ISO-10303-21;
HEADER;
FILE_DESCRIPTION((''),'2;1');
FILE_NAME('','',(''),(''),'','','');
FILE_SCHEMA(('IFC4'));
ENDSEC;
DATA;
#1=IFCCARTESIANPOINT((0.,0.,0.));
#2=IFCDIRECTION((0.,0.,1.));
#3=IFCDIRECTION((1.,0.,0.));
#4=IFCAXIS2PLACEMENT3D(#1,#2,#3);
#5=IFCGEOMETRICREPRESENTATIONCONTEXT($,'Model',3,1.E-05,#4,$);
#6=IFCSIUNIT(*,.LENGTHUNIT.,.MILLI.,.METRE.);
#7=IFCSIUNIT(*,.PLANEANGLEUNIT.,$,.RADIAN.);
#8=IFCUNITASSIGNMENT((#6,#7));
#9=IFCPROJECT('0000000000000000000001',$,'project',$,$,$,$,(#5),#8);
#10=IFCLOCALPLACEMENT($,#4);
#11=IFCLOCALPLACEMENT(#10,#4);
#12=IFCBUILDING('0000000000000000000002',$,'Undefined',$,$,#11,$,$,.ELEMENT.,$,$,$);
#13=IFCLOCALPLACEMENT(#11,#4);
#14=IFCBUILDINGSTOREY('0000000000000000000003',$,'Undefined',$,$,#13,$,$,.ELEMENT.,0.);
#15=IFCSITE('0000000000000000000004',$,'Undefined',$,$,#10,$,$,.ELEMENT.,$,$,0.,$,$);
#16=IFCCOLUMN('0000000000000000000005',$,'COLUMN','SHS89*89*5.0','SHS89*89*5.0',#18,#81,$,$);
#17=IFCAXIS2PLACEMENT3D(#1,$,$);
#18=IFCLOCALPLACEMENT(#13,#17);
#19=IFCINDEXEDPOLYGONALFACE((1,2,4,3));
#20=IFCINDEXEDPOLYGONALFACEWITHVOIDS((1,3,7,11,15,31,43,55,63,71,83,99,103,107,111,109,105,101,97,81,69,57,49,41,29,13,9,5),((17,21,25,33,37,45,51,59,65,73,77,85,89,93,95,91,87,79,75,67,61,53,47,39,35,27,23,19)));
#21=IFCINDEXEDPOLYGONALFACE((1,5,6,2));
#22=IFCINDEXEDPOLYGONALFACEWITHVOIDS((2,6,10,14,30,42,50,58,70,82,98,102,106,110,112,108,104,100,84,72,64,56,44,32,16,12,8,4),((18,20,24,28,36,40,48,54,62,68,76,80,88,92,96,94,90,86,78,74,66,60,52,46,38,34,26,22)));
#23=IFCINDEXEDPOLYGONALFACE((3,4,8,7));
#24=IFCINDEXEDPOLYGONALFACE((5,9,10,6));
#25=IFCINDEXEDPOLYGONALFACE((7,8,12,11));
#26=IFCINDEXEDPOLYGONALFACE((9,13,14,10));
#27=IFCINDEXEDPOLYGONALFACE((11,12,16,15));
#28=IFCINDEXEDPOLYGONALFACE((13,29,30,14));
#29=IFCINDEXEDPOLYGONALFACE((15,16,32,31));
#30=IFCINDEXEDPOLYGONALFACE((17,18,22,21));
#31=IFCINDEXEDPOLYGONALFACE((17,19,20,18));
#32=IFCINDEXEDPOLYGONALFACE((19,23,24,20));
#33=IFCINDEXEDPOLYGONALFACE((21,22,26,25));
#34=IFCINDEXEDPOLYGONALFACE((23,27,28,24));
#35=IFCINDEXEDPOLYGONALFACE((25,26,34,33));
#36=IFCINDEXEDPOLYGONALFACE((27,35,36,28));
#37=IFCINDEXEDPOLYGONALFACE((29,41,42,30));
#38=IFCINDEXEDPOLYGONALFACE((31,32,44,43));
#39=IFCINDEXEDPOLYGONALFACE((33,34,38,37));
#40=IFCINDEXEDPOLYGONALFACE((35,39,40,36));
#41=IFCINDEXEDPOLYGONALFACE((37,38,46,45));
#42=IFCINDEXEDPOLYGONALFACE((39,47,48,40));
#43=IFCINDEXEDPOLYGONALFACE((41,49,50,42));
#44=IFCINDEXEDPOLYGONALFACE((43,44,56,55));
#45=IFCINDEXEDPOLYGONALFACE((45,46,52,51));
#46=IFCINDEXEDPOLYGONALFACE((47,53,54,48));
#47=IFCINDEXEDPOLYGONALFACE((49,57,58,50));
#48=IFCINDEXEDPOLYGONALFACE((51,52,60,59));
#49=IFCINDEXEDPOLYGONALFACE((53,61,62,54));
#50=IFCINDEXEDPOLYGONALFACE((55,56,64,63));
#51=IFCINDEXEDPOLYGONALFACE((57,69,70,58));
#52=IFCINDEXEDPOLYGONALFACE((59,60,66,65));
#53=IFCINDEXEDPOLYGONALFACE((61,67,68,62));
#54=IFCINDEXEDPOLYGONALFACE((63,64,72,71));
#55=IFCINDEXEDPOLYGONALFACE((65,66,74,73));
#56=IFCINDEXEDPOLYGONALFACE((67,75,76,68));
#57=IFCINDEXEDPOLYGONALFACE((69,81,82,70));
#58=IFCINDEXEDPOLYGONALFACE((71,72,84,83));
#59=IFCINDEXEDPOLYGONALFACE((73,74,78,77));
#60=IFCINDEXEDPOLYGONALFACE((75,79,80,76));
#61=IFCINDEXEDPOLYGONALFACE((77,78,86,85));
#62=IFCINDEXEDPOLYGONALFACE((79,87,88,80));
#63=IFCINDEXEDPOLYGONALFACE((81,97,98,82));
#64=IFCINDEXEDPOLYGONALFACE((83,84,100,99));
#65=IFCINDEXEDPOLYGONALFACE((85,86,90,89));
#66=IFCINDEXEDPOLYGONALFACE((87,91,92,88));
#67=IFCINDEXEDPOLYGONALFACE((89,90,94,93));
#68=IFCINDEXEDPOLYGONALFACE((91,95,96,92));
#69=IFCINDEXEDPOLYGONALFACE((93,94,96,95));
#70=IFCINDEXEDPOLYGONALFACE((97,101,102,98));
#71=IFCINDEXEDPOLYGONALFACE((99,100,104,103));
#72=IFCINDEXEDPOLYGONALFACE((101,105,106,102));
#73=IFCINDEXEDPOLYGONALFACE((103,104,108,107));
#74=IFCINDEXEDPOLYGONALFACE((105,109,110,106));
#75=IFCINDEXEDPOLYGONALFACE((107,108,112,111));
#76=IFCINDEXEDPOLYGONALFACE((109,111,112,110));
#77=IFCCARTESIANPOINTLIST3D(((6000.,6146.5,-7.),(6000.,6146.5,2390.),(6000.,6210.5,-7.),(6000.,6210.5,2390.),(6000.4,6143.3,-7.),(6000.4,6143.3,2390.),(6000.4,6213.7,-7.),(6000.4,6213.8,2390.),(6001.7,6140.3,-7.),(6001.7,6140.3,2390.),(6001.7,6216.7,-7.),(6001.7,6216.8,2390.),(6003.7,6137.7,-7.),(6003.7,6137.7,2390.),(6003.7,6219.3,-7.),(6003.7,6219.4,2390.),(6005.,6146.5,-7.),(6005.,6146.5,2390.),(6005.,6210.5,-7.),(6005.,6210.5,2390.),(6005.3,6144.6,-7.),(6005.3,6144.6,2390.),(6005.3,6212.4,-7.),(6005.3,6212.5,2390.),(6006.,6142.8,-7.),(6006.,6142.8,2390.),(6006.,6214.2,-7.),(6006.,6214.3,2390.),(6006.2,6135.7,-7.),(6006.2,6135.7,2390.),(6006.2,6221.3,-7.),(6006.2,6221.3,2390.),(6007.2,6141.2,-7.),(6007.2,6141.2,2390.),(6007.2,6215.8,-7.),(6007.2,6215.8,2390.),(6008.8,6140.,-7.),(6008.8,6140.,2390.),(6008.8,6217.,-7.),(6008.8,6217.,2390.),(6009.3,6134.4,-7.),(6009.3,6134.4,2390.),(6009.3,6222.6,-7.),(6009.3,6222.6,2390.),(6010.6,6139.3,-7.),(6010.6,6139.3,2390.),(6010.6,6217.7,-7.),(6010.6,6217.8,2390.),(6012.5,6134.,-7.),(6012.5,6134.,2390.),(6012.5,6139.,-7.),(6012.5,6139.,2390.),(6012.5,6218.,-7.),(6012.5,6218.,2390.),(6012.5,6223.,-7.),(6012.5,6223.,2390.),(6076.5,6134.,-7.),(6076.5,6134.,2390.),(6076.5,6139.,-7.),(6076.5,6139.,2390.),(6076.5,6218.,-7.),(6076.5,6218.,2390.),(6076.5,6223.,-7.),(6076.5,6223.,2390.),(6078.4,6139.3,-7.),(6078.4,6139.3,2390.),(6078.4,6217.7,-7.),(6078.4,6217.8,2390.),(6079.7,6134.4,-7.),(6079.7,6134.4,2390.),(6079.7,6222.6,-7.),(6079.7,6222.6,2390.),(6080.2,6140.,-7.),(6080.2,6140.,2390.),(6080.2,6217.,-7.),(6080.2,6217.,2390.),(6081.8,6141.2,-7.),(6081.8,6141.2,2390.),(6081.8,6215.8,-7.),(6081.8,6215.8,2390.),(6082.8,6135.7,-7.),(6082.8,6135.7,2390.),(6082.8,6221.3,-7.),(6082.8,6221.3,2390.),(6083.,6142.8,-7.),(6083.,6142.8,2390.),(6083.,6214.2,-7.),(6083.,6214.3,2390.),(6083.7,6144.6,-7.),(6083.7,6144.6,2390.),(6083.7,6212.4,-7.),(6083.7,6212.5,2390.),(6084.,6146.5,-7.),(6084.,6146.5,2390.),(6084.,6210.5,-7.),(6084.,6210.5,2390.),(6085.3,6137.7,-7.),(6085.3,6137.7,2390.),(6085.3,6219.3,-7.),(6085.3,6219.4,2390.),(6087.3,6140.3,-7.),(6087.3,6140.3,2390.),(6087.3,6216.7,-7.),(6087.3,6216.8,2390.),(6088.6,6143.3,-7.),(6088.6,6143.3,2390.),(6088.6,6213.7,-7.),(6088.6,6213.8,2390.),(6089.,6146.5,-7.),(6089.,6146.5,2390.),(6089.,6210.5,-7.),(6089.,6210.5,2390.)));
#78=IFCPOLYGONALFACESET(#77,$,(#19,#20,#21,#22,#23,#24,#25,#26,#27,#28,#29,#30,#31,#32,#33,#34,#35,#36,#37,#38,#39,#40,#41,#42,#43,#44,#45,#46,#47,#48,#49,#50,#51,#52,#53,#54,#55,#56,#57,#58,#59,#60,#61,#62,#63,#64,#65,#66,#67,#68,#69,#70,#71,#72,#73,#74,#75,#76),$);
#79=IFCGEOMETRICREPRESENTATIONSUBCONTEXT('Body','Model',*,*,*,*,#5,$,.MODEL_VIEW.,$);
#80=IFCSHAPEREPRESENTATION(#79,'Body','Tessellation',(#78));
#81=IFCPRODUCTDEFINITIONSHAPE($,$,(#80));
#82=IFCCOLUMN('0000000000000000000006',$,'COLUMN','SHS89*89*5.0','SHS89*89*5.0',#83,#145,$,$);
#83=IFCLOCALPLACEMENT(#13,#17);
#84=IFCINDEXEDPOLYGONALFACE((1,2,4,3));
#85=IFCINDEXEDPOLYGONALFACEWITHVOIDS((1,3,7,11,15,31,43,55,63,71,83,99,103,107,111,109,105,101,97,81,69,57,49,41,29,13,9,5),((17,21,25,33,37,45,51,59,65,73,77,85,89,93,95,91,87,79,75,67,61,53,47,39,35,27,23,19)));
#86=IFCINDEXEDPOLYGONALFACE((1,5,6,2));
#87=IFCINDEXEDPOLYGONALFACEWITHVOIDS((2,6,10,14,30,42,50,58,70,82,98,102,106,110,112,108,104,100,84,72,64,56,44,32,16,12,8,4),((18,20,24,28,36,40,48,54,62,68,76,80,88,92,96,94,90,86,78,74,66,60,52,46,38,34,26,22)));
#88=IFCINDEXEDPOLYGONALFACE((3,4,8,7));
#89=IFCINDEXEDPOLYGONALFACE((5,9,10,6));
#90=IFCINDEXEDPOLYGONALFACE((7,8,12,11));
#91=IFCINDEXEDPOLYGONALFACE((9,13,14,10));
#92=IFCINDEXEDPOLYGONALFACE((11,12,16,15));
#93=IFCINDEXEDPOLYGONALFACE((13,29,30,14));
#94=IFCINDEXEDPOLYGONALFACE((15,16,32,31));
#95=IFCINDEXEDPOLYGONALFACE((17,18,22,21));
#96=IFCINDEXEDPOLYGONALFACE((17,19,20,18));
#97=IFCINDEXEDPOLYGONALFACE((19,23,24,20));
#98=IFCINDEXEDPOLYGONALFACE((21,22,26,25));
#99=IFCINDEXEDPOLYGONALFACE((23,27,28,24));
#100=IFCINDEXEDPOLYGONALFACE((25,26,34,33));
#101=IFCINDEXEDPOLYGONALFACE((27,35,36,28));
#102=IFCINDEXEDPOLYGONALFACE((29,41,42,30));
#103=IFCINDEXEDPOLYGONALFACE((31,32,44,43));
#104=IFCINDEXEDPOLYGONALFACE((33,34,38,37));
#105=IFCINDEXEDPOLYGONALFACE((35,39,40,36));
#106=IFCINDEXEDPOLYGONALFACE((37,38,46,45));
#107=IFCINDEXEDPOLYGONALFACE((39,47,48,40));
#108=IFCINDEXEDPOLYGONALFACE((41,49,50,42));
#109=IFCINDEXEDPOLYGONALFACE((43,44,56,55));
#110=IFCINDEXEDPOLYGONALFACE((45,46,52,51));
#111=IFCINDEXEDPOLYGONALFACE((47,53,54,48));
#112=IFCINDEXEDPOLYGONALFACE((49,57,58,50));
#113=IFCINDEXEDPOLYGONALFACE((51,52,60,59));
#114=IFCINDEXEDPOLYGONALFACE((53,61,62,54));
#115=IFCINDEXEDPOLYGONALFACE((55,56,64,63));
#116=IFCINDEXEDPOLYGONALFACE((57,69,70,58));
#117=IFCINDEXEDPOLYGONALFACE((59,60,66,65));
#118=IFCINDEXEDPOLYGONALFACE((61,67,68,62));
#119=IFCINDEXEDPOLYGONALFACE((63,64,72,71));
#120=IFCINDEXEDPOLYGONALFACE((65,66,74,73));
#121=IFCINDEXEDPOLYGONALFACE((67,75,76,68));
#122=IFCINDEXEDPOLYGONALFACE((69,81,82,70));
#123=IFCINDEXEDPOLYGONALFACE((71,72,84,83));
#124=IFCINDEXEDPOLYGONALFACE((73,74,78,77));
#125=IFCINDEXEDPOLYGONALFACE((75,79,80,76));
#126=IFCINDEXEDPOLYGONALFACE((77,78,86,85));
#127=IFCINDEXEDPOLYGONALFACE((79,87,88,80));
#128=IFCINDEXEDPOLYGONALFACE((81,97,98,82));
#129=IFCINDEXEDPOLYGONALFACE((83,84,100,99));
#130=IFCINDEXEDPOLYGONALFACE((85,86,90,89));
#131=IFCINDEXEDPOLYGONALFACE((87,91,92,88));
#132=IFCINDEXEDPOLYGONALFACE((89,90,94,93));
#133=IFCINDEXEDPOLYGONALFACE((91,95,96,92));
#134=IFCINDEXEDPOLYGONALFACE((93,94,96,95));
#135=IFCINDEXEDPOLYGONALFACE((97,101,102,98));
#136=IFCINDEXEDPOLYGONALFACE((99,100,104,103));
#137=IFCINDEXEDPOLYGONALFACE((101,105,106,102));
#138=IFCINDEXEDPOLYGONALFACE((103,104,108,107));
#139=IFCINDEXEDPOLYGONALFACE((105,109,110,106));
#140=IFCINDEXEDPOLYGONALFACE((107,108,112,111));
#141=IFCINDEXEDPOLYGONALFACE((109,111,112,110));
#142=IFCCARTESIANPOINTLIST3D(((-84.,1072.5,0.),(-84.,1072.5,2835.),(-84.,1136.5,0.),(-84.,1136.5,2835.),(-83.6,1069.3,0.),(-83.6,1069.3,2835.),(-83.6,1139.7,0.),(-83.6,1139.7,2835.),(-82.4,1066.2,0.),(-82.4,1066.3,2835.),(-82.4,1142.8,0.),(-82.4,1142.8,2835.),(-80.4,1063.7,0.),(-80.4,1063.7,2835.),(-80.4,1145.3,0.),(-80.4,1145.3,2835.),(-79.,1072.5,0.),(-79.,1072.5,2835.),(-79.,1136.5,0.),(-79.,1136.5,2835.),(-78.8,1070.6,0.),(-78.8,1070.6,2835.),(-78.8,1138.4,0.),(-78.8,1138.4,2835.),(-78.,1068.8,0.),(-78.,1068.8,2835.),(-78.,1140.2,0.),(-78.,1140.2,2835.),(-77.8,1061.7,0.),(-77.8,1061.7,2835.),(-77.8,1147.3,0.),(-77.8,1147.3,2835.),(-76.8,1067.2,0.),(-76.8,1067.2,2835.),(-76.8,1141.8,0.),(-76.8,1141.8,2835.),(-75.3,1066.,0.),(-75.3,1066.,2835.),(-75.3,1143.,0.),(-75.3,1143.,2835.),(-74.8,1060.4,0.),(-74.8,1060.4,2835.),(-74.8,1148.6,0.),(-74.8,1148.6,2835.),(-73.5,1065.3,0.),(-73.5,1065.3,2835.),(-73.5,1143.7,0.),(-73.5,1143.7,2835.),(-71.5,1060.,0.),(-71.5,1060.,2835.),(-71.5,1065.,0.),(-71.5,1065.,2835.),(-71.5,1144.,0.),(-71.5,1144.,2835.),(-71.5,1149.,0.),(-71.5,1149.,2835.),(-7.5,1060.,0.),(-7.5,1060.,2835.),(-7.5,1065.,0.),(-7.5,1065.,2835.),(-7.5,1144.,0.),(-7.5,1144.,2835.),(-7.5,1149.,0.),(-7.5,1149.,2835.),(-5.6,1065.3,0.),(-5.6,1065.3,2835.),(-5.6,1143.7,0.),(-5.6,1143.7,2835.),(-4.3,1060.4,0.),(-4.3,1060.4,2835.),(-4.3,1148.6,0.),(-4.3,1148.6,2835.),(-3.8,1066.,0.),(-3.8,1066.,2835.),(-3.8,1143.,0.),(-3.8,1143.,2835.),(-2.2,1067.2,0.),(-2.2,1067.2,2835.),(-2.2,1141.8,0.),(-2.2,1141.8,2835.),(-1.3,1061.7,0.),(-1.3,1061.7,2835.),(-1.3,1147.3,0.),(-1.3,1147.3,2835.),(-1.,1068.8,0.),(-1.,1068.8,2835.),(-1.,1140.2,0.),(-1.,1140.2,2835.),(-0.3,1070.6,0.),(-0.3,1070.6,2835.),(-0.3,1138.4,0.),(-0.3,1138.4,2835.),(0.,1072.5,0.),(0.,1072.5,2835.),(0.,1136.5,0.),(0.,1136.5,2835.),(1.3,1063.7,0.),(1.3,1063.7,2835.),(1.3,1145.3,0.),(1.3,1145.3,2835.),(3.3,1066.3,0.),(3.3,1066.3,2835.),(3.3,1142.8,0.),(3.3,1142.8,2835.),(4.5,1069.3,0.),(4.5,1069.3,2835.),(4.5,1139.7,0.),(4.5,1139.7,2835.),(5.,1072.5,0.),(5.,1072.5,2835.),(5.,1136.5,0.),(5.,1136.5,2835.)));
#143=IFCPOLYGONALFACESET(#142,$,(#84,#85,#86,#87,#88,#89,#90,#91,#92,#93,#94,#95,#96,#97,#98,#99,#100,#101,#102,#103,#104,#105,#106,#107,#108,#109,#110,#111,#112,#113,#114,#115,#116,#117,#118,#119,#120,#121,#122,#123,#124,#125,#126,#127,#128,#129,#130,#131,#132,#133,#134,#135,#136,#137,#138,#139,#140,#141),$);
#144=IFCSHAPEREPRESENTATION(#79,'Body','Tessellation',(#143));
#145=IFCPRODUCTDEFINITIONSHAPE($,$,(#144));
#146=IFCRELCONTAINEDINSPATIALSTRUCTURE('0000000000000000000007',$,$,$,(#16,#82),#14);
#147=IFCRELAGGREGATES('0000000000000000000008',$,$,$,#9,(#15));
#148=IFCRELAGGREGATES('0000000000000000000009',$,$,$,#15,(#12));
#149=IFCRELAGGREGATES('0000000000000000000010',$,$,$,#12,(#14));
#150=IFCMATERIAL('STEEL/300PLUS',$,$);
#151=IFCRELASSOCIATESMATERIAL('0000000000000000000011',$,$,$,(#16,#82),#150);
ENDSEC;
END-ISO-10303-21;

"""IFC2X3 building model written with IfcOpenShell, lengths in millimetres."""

from ifc_helpers import new_model, si_unit, frame, origin_with_axes, origin_2d_with_axis, place, context, subcontext, project, spatial, hollow_rectangle, extrude, clip, halfspace, material, element, save


model = new_model("IFC2X3")

# Units and contexts
model_context = context("Model", 3, precision=1e-05, world=origin_with_axes())
body_context = subcontext(model_context, "Body", "Model", "MODEL_VIEW")
ifc_project = project(units=[si_unit("LENGTHUNIT", "METRE", prefix="MILLI"), si_unit("PLANEANGLEUNIT", "RADIAN")], contexts=[model_context])

# Site, building, storey
site_placement = place(None, origin_with_axes())
site = spatial("IfcSite", under=ifc_project, at=site_placement, Name="Undefined", CompositionType="ELEMENT", RefElevation=0.0)
building_placement = place(site_placement, origin_with_axes())
building = spatial("IfcBuilding", under=site, at=building_placement, Name="Undefined", CompositionType="ELEMENT")
storey_placement = place(building_placement, origin_with_axes())
storey = spatial("IfcBuildingStorey", under=building, at=storey_placement, Name="Undefined", CompositionType="ELEMENT", Elevation=0.0)

# Columns
ifc_material_1 = material(Name="STEEL/300PLUS")
column_1_placement = place(storey_placement, frame((6044.5, 6178.5, -7.0), z_axis=(0.0, 0.0, 1.0), x_axis=(1.0, 0.0, 0.0)))
element("IfcColumn", 1, at=column_1_placement, inside=storey, material=ifc_material_1, Name="COLUMN", Description="SHS89*89*5.0", ObjectType="SHS89*89*5.0", context=body_context, shape_type="Clipping", body=[
    clip(extrude(hollow_rectangle(XDim=89.0, YDim=89.0, WallThickness=5.0, InnerFilletRadius=7.5, OuterFilletRadius=12.5, at=origin_2d_with_axis()), frame((0.0, 0.0, 2407.0), z_axis=(0.0, -0.000008, -1.0), x_axis=(-1.0, 0.0, 0.0)), (0.0, 0.0, 1.0), 2407.0), halfspace(frame((-44.5, 44.5, 2397.0), z_axis=(0.0, 0.000008, 1.0), x_axis=(1.0, 0.0, 0.0)), False)),
])
column_2_placement = place(storey_placement, frame((-39.5, 1104.5, 0.0), z_axis=(0.0, 0.0, 1.0), x_axis=(1.0, 0.0, 0.0)))
element("IfcColumn", 2, at=column_2_placement, inside=storey, material=ifc_material_1, Name="COLUMN", Description="SHS89*89*5.0", ObjectType="SHS89*89*5.0", context=body_context, shape_type="Clipping", body=[
    clip(clip(clip(extrude(hollow_rectangle(XDim=89.0, YDim=89.0, WallThickness=5.0, InnerFilletRadius=7.5, OuterFilletRadius=12.5, at=origin_2d_with_axis()), frame((0.0, 0.0, 2845.0), z_axis=(0.0, 0.0, -1.0), x_axis=(-1.0, 0.0, 0.0)), (0.0, 0.0, 1.0), 2845.0), halfspace(frame((-44.5, -44.5, 2835.0), z_axis=(0.0, 0.0, 1.0), x_axis=(0.0, 1.0, 0.0)), False)), halfspace(frame((-44.5, -44.5, 2835.0), z_axis=(0.0, 0.0, 1.0), x_axis=(0.0, 1.0, 0.0)), False)), halfspace(frame((44.5, 44.5, 2835.0), z_axis=(0.0, 1.0, 0.0), x_axis=(0.0, 0.0, 1.0)), False)),
])

save(model, "model.ifc")
